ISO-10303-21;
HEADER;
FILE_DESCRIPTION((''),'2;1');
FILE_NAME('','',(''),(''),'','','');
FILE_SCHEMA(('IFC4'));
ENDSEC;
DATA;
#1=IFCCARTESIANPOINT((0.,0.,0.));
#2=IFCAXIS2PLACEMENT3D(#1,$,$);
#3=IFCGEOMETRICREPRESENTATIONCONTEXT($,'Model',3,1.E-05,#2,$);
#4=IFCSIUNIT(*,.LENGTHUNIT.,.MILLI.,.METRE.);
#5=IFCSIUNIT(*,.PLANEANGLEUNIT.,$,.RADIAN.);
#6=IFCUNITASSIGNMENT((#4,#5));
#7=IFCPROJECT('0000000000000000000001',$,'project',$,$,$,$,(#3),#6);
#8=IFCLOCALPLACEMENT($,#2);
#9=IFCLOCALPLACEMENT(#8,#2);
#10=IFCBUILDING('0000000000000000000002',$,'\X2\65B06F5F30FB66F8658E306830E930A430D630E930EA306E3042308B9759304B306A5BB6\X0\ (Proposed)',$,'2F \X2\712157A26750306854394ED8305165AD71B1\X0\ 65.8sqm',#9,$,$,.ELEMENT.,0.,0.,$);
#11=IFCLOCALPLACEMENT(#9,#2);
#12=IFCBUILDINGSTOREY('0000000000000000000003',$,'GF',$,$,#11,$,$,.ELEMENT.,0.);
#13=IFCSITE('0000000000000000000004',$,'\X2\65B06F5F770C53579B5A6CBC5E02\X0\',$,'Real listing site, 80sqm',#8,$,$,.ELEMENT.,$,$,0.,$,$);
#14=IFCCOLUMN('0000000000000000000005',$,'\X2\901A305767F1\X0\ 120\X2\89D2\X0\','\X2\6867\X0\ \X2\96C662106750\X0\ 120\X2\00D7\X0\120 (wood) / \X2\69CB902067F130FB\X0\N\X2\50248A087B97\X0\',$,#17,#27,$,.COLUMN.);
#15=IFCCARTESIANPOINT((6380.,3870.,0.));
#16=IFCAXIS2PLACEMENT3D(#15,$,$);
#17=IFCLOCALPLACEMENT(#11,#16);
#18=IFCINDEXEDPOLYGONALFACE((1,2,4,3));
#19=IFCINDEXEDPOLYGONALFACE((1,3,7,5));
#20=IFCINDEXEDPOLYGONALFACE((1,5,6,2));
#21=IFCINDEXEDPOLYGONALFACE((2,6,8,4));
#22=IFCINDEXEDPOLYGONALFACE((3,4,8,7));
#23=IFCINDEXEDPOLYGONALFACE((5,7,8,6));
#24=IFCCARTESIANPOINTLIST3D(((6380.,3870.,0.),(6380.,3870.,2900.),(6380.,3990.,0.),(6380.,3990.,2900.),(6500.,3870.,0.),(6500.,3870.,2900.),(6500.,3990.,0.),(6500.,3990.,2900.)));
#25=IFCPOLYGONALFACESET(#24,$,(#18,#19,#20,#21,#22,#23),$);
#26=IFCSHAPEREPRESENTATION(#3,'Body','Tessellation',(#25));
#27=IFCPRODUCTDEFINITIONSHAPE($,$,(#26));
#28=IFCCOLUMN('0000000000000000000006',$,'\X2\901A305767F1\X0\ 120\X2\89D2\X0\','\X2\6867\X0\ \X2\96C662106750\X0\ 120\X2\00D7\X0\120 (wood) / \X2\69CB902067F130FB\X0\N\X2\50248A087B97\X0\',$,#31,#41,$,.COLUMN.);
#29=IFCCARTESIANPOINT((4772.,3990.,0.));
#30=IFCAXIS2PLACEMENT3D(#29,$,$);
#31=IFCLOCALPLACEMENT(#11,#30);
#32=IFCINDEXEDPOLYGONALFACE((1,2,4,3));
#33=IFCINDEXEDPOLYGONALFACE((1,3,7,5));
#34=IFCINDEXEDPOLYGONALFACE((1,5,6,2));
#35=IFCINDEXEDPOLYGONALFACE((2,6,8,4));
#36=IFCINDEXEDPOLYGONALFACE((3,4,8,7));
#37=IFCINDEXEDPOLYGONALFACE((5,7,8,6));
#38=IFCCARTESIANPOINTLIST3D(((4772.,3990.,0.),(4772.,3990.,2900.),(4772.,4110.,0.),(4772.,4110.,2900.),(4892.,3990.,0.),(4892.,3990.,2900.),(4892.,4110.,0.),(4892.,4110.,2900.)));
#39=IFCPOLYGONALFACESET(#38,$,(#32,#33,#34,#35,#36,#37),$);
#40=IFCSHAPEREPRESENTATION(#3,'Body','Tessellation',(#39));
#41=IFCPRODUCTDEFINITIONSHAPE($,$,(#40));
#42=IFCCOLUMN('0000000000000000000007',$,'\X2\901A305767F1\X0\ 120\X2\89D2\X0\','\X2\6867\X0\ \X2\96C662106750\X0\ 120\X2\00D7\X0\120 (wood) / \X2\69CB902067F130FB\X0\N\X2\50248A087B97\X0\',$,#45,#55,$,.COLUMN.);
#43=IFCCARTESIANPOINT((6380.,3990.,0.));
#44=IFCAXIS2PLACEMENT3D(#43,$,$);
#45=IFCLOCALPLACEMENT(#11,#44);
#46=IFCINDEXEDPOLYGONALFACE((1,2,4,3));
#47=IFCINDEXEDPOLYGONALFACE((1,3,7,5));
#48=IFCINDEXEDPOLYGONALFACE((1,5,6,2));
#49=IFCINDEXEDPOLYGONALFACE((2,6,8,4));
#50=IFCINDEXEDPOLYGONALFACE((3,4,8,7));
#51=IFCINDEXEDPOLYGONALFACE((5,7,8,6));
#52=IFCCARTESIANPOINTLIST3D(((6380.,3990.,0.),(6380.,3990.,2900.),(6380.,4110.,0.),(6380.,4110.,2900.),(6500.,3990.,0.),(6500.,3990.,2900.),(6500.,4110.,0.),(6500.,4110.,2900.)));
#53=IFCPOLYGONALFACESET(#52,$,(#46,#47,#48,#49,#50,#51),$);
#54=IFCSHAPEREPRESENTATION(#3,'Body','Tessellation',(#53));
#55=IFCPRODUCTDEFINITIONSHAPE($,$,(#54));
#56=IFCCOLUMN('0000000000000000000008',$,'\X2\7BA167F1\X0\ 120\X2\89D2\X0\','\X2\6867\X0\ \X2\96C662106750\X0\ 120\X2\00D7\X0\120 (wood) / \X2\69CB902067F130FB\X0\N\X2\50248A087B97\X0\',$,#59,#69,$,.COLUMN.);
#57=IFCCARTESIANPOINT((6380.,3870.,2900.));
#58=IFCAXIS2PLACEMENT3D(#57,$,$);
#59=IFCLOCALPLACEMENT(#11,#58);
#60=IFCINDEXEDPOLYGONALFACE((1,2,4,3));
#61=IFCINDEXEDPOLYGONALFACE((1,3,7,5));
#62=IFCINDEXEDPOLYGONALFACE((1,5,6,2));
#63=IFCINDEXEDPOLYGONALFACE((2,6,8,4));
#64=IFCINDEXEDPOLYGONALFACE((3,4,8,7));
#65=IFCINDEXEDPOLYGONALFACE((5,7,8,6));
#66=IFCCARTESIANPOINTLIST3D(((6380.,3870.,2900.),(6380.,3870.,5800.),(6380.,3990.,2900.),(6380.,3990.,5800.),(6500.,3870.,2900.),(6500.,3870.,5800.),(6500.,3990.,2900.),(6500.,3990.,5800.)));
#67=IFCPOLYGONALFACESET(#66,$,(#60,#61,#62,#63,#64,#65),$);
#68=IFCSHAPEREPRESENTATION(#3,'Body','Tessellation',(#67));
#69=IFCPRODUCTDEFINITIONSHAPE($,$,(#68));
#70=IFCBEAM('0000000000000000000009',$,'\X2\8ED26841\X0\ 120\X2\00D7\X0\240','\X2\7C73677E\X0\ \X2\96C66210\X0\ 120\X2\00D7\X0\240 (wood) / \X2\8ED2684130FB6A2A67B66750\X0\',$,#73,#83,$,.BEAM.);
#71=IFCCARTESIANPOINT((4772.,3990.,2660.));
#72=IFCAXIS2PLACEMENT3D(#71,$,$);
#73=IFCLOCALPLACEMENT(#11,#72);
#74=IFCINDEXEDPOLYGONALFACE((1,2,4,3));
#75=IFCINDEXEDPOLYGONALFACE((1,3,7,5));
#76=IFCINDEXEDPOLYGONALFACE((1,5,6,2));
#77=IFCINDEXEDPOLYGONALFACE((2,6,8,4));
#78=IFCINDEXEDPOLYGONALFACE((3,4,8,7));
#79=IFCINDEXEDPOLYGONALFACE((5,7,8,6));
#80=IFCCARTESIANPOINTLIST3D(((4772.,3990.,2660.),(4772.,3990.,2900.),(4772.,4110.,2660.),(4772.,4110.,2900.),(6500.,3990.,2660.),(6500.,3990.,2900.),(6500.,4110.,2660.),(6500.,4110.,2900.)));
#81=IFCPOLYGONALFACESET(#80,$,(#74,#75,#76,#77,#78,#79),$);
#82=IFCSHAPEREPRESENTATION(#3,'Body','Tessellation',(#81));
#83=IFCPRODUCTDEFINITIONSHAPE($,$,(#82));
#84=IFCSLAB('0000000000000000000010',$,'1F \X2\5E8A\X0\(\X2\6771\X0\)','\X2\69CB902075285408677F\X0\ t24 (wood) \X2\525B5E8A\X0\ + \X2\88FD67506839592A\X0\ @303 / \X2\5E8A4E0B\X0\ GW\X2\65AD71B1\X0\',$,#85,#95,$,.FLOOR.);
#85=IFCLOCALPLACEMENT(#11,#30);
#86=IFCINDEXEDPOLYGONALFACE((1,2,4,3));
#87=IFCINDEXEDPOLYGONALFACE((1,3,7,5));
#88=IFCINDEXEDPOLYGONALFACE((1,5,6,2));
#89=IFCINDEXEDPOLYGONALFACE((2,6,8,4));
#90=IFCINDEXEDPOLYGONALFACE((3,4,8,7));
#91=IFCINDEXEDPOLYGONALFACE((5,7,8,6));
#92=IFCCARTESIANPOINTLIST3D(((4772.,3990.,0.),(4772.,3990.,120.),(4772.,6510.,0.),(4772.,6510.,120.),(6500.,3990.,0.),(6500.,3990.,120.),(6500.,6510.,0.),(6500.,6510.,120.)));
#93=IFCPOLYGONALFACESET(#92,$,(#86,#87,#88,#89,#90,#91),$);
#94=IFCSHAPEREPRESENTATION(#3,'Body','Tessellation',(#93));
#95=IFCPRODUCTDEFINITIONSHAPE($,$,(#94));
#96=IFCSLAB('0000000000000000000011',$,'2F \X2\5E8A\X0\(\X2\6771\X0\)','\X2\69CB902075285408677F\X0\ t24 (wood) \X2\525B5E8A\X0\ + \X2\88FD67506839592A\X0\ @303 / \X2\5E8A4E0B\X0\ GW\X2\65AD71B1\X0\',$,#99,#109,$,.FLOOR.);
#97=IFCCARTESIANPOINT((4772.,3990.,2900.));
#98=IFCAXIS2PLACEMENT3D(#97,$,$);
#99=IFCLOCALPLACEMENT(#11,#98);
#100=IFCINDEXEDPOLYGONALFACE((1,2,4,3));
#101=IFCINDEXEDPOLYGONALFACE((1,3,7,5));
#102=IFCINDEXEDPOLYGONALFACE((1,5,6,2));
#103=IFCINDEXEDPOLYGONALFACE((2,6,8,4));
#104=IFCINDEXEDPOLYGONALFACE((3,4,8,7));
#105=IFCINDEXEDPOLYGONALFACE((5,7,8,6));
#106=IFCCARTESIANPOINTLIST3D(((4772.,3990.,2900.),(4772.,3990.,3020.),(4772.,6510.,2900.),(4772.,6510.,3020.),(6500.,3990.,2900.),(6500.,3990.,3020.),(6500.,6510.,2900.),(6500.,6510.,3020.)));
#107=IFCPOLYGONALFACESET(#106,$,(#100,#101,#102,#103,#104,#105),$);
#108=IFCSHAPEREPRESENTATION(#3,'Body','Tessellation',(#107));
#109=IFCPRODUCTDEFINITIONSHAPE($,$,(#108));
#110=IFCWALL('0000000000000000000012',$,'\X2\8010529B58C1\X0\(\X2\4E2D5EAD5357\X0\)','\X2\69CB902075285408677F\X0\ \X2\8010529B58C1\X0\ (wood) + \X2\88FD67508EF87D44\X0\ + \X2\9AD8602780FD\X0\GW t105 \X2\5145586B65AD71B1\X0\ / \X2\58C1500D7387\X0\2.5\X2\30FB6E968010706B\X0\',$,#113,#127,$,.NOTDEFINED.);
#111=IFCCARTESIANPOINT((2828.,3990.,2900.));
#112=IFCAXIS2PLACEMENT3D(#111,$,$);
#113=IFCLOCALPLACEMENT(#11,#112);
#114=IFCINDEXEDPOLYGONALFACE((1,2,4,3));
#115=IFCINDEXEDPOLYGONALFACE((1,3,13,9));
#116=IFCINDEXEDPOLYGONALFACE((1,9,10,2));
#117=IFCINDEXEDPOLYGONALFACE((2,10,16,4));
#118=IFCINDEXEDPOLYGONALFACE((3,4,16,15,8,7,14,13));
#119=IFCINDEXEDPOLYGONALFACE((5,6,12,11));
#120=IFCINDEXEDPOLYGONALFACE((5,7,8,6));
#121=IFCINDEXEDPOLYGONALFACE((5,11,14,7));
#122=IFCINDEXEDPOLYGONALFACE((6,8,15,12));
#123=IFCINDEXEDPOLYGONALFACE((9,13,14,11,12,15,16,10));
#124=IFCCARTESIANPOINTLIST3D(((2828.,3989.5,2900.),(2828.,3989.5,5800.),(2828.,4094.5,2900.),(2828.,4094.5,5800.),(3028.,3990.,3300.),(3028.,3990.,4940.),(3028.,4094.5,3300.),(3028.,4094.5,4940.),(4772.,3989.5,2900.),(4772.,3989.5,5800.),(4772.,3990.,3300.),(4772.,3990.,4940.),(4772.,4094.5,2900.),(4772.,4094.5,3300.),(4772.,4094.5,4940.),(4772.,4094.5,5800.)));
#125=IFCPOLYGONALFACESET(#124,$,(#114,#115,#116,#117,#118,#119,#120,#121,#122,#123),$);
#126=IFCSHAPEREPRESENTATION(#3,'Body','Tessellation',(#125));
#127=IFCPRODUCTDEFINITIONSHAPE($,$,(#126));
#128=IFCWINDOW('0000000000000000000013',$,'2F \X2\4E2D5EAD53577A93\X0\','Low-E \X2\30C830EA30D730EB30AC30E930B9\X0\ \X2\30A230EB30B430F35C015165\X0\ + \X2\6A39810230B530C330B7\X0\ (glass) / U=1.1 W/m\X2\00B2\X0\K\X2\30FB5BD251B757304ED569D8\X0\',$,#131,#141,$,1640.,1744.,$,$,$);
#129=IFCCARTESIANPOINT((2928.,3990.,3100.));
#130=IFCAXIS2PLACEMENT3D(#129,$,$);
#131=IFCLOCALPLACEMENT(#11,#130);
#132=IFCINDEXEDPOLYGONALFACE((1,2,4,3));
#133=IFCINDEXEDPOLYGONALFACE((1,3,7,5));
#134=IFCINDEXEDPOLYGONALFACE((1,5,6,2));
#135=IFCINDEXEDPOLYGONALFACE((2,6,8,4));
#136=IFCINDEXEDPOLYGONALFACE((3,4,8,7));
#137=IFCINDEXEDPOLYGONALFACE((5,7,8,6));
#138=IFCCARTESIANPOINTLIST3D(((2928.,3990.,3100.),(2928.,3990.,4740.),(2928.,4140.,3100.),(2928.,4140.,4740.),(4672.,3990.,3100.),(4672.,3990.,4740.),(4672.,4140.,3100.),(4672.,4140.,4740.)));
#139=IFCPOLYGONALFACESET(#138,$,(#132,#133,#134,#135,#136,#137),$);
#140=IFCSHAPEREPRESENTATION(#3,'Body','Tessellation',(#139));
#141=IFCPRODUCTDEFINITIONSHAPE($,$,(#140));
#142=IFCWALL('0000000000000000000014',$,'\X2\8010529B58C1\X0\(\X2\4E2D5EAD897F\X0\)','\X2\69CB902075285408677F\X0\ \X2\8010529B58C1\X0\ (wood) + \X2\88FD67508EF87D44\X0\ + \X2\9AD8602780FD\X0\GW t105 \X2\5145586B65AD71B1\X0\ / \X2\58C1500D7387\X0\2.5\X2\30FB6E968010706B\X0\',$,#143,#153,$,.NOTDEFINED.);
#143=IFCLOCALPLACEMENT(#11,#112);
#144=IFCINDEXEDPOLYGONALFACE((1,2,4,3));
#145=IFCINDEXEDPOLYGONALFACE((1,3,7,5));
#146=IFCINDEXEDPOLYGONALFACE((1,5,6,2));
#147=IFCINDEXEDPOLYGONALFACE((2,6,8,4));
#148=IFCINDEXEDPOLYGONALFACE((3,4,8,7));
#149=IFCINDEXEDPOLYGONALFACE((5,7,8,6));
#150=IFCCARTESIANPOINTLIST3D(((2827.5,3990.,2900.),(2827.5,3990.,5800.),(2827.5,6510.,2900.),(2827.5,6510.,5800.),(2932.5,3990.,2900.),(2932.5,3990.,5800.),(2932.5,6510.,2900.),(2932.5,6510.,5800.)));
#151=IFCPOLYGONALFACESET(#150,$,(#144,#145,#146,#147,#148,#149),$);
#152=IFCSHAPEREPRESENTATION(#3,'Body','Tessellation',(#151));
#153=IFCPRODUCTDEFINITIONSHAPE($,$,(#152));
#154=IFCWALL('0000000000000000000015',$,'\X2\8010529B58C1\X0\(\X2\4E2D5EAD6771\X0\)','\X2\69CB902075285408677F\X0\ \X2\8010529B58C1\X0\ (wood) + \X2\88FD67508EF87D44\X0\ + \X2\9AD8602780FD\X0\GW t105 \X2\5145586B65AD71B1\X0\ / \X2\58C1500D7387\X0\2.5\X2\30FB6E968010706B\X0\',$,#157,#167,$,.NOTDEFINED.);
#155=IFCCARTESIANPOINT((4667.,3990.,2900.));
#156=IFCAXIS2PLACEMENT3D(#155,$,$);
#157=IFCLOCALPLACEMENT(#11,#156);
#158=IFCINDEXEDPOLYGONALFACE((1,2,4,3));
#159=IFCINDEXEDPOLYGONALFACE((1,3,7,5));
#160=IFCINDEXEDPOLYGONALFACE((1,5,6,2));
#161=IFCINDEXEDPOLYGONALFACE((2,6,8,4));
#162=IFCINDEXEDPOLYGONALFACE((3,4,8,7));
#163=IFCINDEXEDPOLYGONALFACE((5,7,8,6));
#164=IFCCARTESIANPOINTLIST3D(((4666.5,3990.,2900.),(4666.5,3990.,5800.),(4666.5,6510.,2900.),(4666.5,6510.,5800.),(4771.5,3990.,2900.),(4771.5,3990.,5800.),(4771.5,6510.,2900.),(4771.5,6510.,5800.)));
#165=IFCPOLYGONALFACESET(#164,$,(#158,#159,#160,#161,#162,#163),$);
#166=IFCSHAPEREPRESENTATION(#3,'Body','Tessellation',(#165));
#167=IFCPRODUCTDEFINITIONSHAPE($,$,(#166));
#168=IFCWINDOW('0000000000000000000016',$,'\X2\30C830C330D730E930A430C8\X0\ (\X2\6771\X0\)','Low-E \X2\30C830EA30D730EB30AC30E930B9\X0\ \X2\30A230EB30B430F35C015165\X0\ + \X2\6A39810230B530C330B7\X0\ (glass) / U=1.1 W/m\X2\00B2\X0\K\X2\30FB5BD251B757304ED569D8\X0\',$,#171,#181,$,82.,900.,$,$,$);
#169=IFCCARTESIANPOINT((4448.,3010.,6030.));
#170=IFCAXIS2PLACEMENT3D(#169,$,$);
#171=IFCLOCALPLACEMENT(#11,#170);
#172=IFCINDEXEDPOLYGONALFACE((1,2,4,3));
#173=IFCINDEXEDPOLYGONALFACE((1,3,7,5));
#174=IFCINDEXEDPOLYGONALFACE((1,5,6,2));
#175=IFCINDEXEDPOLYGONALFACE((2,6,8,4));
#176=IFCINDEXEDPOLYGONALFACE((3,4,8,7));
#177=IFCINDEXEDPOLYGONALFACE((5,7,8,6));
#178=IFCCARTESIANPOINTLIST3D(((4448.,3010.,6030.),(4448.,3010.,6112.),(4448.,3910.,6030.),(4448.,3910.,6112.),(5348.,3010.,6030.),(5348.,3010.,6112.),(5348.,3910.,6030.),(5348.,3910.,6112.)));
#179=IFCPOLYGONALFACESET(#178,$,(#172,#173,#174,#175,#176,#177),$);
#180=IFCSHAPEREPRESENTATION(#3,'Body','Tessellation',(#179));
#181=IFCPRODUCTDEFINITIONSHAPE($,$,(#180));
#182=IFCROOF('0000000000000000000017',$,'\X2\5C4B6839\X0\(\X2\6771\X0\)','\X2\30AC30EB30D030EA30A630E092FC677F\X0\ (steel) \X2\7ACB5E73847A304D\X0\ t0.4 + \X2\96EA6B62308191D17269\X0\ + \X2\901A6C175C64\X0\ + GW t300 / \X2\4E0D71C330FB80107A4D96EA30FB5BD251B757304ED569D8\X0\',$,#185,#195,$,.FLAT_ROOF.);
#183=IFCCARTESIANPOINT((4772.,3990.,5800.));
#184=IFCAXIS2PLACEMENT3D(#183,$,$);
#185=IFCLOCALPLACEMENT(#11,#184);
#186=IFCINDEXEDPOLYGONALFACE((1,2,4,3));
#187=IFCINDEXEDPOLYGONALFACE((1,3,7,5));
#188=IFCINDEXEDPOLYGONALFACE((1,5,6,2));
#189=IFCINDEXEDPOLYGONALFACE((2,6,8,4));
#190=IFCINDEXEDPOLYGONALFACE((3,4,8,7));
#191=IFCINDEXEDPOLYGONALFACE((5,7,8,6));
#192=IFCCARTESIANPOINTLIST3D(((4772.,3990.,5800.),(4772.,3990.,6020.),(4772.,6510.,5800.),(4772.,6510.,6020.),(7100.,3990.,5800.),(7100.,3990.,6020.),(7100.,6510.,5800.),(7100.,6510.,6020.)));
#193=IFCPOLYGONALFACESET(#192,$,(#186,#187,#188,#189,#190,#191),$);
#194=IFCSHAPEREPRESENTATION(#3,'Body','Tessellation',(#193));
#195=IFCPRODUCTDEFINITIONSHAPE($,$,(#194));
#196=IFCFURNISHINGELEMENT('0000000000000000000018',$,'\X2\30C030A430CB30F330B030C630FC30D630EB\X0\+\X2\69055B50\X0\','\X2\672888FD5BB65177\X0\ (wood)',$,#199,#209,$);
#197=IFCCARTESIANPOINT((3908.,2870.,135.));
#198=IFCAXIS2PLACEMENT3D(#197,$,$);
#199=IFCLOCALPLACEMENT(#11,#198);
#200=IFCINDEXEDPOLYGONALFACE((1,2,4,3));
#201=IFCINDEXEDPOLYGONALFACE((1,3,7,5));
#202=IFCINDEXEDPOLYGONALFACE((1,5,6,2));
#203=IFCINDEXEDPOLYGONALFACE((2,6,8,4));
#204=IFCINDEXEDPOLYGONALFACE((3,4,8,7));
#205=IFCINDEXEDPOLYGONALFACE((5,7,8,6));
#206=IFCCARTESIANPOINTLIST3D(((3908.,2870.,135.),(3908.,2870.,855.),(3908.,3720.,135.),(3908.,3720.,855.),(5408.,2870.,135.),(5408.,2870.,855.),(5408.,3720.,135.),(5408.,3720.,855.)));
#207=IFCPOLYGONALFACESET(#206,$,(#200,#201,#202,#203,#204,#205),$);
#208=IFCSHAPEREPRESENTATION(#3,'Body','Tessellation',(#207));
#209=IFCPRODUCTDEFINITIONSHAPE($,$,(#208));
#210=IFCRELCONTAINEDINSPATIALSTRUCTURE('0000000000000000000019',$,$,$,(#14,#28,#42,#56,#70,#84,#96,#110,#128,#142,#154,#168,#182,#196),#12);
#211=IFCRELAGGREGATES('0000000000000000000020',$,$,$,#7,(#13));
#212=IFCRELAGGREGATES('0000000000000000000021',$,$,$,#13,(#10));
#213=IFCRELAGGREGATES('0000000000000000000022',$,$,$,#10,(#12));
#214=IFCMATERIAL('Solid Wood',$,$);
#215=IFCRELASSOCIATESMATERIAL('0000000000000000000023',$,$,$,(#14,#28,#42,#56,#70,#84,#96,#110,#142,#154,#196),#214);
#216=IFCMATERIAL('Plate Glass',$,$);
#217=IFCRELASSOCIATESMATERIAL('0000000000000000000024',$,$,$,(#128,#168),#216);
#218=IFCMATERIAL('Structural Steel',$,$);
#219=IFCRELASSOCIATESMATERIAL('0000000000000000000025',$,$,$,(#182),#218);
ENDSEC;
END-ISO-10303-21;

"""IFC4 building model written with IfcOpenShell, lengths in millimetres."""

from ifc_helpers import new_model, si_unit, frame, frame_2d, origin, place, context, project, spatial, rectangle, extrude, material, element, fill, save


model = new_model("IFC4")

# Units and contexts
model_context = context("Model", 3, precision=1e-05, world=origin())
ifc_project = project(units=[si_unit("LENGTHUNIT", "METRE", prefix="MILLI"), si_unit("PLANEANGLEUNIT", "RADIAN")], contexts=[model_context])

# Site, building, storey
site_placement = place(None, origin())
site = spatial("IfcSite", under=ifc_project, at=site_placement, Name="新潟県南魚沼市", ObjectType="Real listing site, 80sqm", CompositionType="ELEMENT", RefElevation=0.0)
building_placement = place(site_placement, origin())
building = spatial("IfcBuilding", under=site, at=building_placement, Name="新潟・書斎とライブラリのある静かな家 (Proposed)", ObjectType="2F 無垢材と吹付け断熱 65.8sqm", CompositionType="ELEMENT", ElevationOfRefHeight=0.0, ElevationOfTerrain=0.0)
storey_placement = place(building_placement, origin())
storey = spatial("IfcBuildingStorey", under=building, at=storey_placement, Name="GF", CompositionType="ELEMENT", Elevation=0.0)

# Columns
ifc_material_1 = material(Name="Solid Wood")
column_1_placement = place(storey_placement, frame((6380.0, 3870.0, 0.0)))
element("IfcColumn", 1, at=column_1_placement, inside=storey, material=ifc_material_1, Name="通し柱 120角", Description="桧 集成材 120×120 (wood) / 構造柱・N値計算", PredefinedType="COLUMN", context=model_context, shape_type="SweptSolid", body=[
    extrude(rectangle(XDim=120.0, YDim=120.0, at=frame_2d((60.0, 60.0))), frame((6380.0, 3870.0, 0.0)), (0.0, 0.0, 1.0), 2900.0),
])
column_2_placement = place(storey_placement, frame((4772.0, 3990.0, 0.0)))
element("IfcColumn", 2, at=column_2_placement, inside=storey, material=ifc_material_1, Name="通し柱 120角", Description="桧 集成材 120×120 (wood) / 構造柱・N値計算", PredefinedType="COLUMN", context=model_context, shape_type="SweptSolid", body=[
    extrude(rectangle(XDim=120.0, YDim=120.0, at=frame_2d((60.0, 60.0))), frame((4772.0, 3990.0, 0.0)), (0.0, 0.0, 1.0), 2900.0),
])
column_3_placement = place(storey_placement, frame((6380.0, 3990.0, 0.0)))
element("IfcColumn", 3, at=column_3_placement, inside=storey, material=ifc_material_1, Name="通し柱 120角", Description="桧 集成材 120×120 (wood) / 構造柱・N値計算", PredefinedType="COLUMN", context=model_context, shape_type="SweptSolid", body=[
    extrude(rectangle(XDim=120.0, YDim=120.0, at=frame_2d((60.0, 60.0))), frame((6380.0, 3990.0, 0.0)), (0.0, 0.0, 1.0), 2900.0),
])
column_4_placement = place(storey_placement, frame((6380.0, 3870.0, 2900.0)))
element("IfcColumn", 4, at=column_4_placement, inside=storey, material=ifc_material_1, Name="管柱 120角", Description="桧 集成材 120×120 (wood) / 構造柱・N値計算", PredefinedType="COLUMN", context=model_context, shape_type="SweptSolid", body=[
    extrude(rectangle(XDim=120.0, YDim=120.0, at=frame_2d((60.0, 60.0))), frame((6380.0, 3870.0, 2900.0)), (0.0, 0.0, 1.0), 2900.0),
])

# Beam
beam_1_placement = place(storey_placement, frame((4772.0, 3990.0, 2660.0)))
element("IfcBeam", 5, at=beam_1_placement, inside=storey, material=ifc_material_1, Name="軒桁 120×240", Description="米松 集成 120×240 (wood) / 軒桁・横架材", PredefinedType="BEAM", context=model_context, shape_type="SweptSolid", body=[
    extrude(rectangle(XDim=1728.0, YDim=120.0, at=frame_2d((864.0, 60.0))), frame((4772.0, 3990.0, 2660.0)), (0.0, 0.0, 1.0), 240.0),
])

# Slabs
slab_1_placement = place(storey_placement, frame((4772.0, 3990.0, 0.0)))
element("IfcSlab", 6, at=slab_1_placement, inside=storey, material=ifc_material_1, Name="1F 床(東)", Description="構造用合板 t24 (wood) 剛床 + 製材根太 @303 / 床下 GW断熱", PredefinedType="FLOOR", context=model_context, shape_type="SweptSolid", body=[
    extrude(rectangle(XDim=1728.0, YDim=2520.0, at=frame_2d((864.0, 1260.0))), frame((4772.0, 3990.0, 0.0)), (0.0, 0.0, 1.0), 120.0),
])
slab_2_placement = place(storey_placement, frame((4772.0, 3990.0, 2900.0)))
element("IfcSlab", 7, at=slab_2_placement, inside=storey, material=ifc_material_1, Name="2F 床(東)", Description="構造用合板 t24 (wood) 剛床 + 製材根太 @303 / 床下 GW断熱", PredefinedType="FLOOR", context=model_context, shape_type="SweptSolid", body=[
    extrude(rectangle(XDim=1728.0, YDim=2520.0, at=frame_2d((864.0, 1260.0))), frame((4772.0, 3990.0, 2900.0)), (0.0, 0.0, 1.0), 120.0),
])

# Wall, opening, window
wall_1_placement = place(storey_placement, frame((2828.0, 3990.0, 2900.0)))
wall_1 = element("IfcWall", 8, at=wall_1_placement, inside=storey, material=ifc_material_1, Name="耐力壁(中庭南)", Description="構造用合板 耐力壁 (wood) + 製材軸組 + 高性能GW t105 充填断熱 / 壁倍率2.5・準耐火", PredefinedType="NOTDEFINED", context=model_context, shape_type="SweptSolid", body=[
    extrude(rectangle(XDim=1944.0, YDim=105.0, at=frame_2d((972.0, 52.0))), frame((2828.0, 3990.0, 2900.0)), (0.0, 0.0, 1.0), 2900.0),
])
opening_placement = place(storey_placement, frame((2928.0, 3990.0, 3100.0)))
opening = element("IfcOpeningElement", 9, at=opening_placement, cuts=wall_1, PredefinedType="NOTDEFINED", context=model_context, shape_type="SweptSolid", body=[
    extrude(rectangle(XDim=1744.0, YDim=150.0, at=frame_2d((872.0, 75.0))), frame((2928.0, 3990.0, 3100.0)), (0.0, 0.0, 1.0), 1640.0),
])
ifc_material_2 = material(Name="Plate Glass")
window_1_placement = place(storey_placement, frame((2928.0, 3990.0, 3100.0)))
window_1 = element("IfcWindow", 10, at=window_1_placement, inside=storey, material=ifc_material_2, Name="2F 中庭南窓", Description="Low-E トリプルガラス アルゴン封入 + 樹脂サッシ (glass) / U=1.1 W/m²K・寒冷地仕様", OverallHeight=1640.0, OverallWidth=1744.0, context=model_context, shape_type="SweptSolid", body=[
    extrude(rectangle(XDim=1744.0, YDim=150.0, at=frame_2d((872.0, 75.0))), frame((2928.0, 3990.0, 3100.0)), (0.0, 0.0, 1.0), 1640.0),
])
fill(opening, window_1)

# Walls
wall_2_placement = place(storey_placement, frame((2828.0, 3990.0, 2900.0)))
element("IfcWall", 11, at=wall_2_placement, inside=storey, material=ifc_material_1, Name="耐力壁(中庭西)", Description="構造用合板 耐力壁 (wood) + 製材軸組 + 高性能GW t105 充填断熱 / 壁倍率2.5・準耐火", PredefinedType="NOTDEFINED", context=model_context, shape_type="SweptSolid", body=[
    extrude(rectangle(XDim=105.0, YDim=2520.0, at=frame_2d((52.0, 1260.0))), frame((2828.0, 3990.0, 2900.0)), (0.0, 0.0, 1.0), 2900.0),
])
wall_3_placement = place(storey_placement, frame((4667.0, 3990.0, 2900.0)))
element("IfcWall", 12, at=wall_3_placement, inside=storey, material=ifc_material_1, Name="耐力壁(中庭東)", Description="構造用合板 耐力壁 (wood) + 製材軸組 + 高性能GW t105 充填断熱 / 壁倍率2.5・準耐火", PredefinedType="NOTDEFINED", context=model_context, shape_type="SweptSolid", body=[
    extrude(rectangle(XDim=105.0, YDim=2520.0, at=frame_2d((52.0, 1260.0))), frame((4667.0, 3990.0, 2900.0)), (0.0, 0.0, 1.0), 2900.0),
])

# Window
window_2_placement = place(storey_placement, frame((4448.0, 3010.0, 6030.0)))
element("IfcWindow", 13, at=window_2_placement, inside=storey, material=ifc_material_2, Name="トップライト (東)", Description="Low-E トリプルガラス アルゴン封入 + 樹脂サッシ (glass) / U=1.1 W/m²K・寒冷地仕様", OverallHeight=82.0, OverallWidth=900.0, context=model_context, shape_type="SweptSolid", body=[
    extrude(rectangle(XDim=900.0, YDim=900.0, at=frame_2d((450.0, 450.0))), frame((4448.0, 3010.0, 6030.0)), (0.0, 0.0, 1.0), 82.0),
])

# Roof
ifc_material_3 = material(Name="Structural Steel")
for number, where, name in (
    (14, (4772.0, 3990.0, 5800.0), "屋根(東)"),
):
    element("IfcRoof", number, at=place(storey_placement, frame(where)), inside=storey, material=ifc_material_3, Name=name, Description="ガルバリウム鋼板 (steel) 立平葺き t0.4 + 雪止め金物 + 通気層 + GW t300 / 不燃・耐積雪・寒冷地仕様", PredefinedType="FLAT_ROOF", context=model_context, shape_type="SweptSolid", body=[
        extrude(rectangle(XDim=2328.0, YDim=2520.0, at=frame_2d((1164.0, 1260.0))), frame((4772.0, 3990.0, 5800.0)), (0.0, 0.0, 1.0), 220.0),
    ])

# Furnishing element
furnishing_1_placement = place(storey_placement, frame((3908.0, 2870.0, 135.0)))
element("IfcFurnishingElement", 15, at=furnishing_1_placement, inside=storey, material=ifc_material_1, Name="ダイニングテーブル+椅子", Description="木製家具 (wood)", context=model_context, shape_type="SweptSolid", body=[
    extrude(rectangle(XDim=1500.0, YDim=850.0, at=frame_2d((750.0, 425.0))), frame((3908.0, 2870.0, 135.0)), (0.0, 0.0, 1.0), 720.0),
])

save(model, "model.ifc")
